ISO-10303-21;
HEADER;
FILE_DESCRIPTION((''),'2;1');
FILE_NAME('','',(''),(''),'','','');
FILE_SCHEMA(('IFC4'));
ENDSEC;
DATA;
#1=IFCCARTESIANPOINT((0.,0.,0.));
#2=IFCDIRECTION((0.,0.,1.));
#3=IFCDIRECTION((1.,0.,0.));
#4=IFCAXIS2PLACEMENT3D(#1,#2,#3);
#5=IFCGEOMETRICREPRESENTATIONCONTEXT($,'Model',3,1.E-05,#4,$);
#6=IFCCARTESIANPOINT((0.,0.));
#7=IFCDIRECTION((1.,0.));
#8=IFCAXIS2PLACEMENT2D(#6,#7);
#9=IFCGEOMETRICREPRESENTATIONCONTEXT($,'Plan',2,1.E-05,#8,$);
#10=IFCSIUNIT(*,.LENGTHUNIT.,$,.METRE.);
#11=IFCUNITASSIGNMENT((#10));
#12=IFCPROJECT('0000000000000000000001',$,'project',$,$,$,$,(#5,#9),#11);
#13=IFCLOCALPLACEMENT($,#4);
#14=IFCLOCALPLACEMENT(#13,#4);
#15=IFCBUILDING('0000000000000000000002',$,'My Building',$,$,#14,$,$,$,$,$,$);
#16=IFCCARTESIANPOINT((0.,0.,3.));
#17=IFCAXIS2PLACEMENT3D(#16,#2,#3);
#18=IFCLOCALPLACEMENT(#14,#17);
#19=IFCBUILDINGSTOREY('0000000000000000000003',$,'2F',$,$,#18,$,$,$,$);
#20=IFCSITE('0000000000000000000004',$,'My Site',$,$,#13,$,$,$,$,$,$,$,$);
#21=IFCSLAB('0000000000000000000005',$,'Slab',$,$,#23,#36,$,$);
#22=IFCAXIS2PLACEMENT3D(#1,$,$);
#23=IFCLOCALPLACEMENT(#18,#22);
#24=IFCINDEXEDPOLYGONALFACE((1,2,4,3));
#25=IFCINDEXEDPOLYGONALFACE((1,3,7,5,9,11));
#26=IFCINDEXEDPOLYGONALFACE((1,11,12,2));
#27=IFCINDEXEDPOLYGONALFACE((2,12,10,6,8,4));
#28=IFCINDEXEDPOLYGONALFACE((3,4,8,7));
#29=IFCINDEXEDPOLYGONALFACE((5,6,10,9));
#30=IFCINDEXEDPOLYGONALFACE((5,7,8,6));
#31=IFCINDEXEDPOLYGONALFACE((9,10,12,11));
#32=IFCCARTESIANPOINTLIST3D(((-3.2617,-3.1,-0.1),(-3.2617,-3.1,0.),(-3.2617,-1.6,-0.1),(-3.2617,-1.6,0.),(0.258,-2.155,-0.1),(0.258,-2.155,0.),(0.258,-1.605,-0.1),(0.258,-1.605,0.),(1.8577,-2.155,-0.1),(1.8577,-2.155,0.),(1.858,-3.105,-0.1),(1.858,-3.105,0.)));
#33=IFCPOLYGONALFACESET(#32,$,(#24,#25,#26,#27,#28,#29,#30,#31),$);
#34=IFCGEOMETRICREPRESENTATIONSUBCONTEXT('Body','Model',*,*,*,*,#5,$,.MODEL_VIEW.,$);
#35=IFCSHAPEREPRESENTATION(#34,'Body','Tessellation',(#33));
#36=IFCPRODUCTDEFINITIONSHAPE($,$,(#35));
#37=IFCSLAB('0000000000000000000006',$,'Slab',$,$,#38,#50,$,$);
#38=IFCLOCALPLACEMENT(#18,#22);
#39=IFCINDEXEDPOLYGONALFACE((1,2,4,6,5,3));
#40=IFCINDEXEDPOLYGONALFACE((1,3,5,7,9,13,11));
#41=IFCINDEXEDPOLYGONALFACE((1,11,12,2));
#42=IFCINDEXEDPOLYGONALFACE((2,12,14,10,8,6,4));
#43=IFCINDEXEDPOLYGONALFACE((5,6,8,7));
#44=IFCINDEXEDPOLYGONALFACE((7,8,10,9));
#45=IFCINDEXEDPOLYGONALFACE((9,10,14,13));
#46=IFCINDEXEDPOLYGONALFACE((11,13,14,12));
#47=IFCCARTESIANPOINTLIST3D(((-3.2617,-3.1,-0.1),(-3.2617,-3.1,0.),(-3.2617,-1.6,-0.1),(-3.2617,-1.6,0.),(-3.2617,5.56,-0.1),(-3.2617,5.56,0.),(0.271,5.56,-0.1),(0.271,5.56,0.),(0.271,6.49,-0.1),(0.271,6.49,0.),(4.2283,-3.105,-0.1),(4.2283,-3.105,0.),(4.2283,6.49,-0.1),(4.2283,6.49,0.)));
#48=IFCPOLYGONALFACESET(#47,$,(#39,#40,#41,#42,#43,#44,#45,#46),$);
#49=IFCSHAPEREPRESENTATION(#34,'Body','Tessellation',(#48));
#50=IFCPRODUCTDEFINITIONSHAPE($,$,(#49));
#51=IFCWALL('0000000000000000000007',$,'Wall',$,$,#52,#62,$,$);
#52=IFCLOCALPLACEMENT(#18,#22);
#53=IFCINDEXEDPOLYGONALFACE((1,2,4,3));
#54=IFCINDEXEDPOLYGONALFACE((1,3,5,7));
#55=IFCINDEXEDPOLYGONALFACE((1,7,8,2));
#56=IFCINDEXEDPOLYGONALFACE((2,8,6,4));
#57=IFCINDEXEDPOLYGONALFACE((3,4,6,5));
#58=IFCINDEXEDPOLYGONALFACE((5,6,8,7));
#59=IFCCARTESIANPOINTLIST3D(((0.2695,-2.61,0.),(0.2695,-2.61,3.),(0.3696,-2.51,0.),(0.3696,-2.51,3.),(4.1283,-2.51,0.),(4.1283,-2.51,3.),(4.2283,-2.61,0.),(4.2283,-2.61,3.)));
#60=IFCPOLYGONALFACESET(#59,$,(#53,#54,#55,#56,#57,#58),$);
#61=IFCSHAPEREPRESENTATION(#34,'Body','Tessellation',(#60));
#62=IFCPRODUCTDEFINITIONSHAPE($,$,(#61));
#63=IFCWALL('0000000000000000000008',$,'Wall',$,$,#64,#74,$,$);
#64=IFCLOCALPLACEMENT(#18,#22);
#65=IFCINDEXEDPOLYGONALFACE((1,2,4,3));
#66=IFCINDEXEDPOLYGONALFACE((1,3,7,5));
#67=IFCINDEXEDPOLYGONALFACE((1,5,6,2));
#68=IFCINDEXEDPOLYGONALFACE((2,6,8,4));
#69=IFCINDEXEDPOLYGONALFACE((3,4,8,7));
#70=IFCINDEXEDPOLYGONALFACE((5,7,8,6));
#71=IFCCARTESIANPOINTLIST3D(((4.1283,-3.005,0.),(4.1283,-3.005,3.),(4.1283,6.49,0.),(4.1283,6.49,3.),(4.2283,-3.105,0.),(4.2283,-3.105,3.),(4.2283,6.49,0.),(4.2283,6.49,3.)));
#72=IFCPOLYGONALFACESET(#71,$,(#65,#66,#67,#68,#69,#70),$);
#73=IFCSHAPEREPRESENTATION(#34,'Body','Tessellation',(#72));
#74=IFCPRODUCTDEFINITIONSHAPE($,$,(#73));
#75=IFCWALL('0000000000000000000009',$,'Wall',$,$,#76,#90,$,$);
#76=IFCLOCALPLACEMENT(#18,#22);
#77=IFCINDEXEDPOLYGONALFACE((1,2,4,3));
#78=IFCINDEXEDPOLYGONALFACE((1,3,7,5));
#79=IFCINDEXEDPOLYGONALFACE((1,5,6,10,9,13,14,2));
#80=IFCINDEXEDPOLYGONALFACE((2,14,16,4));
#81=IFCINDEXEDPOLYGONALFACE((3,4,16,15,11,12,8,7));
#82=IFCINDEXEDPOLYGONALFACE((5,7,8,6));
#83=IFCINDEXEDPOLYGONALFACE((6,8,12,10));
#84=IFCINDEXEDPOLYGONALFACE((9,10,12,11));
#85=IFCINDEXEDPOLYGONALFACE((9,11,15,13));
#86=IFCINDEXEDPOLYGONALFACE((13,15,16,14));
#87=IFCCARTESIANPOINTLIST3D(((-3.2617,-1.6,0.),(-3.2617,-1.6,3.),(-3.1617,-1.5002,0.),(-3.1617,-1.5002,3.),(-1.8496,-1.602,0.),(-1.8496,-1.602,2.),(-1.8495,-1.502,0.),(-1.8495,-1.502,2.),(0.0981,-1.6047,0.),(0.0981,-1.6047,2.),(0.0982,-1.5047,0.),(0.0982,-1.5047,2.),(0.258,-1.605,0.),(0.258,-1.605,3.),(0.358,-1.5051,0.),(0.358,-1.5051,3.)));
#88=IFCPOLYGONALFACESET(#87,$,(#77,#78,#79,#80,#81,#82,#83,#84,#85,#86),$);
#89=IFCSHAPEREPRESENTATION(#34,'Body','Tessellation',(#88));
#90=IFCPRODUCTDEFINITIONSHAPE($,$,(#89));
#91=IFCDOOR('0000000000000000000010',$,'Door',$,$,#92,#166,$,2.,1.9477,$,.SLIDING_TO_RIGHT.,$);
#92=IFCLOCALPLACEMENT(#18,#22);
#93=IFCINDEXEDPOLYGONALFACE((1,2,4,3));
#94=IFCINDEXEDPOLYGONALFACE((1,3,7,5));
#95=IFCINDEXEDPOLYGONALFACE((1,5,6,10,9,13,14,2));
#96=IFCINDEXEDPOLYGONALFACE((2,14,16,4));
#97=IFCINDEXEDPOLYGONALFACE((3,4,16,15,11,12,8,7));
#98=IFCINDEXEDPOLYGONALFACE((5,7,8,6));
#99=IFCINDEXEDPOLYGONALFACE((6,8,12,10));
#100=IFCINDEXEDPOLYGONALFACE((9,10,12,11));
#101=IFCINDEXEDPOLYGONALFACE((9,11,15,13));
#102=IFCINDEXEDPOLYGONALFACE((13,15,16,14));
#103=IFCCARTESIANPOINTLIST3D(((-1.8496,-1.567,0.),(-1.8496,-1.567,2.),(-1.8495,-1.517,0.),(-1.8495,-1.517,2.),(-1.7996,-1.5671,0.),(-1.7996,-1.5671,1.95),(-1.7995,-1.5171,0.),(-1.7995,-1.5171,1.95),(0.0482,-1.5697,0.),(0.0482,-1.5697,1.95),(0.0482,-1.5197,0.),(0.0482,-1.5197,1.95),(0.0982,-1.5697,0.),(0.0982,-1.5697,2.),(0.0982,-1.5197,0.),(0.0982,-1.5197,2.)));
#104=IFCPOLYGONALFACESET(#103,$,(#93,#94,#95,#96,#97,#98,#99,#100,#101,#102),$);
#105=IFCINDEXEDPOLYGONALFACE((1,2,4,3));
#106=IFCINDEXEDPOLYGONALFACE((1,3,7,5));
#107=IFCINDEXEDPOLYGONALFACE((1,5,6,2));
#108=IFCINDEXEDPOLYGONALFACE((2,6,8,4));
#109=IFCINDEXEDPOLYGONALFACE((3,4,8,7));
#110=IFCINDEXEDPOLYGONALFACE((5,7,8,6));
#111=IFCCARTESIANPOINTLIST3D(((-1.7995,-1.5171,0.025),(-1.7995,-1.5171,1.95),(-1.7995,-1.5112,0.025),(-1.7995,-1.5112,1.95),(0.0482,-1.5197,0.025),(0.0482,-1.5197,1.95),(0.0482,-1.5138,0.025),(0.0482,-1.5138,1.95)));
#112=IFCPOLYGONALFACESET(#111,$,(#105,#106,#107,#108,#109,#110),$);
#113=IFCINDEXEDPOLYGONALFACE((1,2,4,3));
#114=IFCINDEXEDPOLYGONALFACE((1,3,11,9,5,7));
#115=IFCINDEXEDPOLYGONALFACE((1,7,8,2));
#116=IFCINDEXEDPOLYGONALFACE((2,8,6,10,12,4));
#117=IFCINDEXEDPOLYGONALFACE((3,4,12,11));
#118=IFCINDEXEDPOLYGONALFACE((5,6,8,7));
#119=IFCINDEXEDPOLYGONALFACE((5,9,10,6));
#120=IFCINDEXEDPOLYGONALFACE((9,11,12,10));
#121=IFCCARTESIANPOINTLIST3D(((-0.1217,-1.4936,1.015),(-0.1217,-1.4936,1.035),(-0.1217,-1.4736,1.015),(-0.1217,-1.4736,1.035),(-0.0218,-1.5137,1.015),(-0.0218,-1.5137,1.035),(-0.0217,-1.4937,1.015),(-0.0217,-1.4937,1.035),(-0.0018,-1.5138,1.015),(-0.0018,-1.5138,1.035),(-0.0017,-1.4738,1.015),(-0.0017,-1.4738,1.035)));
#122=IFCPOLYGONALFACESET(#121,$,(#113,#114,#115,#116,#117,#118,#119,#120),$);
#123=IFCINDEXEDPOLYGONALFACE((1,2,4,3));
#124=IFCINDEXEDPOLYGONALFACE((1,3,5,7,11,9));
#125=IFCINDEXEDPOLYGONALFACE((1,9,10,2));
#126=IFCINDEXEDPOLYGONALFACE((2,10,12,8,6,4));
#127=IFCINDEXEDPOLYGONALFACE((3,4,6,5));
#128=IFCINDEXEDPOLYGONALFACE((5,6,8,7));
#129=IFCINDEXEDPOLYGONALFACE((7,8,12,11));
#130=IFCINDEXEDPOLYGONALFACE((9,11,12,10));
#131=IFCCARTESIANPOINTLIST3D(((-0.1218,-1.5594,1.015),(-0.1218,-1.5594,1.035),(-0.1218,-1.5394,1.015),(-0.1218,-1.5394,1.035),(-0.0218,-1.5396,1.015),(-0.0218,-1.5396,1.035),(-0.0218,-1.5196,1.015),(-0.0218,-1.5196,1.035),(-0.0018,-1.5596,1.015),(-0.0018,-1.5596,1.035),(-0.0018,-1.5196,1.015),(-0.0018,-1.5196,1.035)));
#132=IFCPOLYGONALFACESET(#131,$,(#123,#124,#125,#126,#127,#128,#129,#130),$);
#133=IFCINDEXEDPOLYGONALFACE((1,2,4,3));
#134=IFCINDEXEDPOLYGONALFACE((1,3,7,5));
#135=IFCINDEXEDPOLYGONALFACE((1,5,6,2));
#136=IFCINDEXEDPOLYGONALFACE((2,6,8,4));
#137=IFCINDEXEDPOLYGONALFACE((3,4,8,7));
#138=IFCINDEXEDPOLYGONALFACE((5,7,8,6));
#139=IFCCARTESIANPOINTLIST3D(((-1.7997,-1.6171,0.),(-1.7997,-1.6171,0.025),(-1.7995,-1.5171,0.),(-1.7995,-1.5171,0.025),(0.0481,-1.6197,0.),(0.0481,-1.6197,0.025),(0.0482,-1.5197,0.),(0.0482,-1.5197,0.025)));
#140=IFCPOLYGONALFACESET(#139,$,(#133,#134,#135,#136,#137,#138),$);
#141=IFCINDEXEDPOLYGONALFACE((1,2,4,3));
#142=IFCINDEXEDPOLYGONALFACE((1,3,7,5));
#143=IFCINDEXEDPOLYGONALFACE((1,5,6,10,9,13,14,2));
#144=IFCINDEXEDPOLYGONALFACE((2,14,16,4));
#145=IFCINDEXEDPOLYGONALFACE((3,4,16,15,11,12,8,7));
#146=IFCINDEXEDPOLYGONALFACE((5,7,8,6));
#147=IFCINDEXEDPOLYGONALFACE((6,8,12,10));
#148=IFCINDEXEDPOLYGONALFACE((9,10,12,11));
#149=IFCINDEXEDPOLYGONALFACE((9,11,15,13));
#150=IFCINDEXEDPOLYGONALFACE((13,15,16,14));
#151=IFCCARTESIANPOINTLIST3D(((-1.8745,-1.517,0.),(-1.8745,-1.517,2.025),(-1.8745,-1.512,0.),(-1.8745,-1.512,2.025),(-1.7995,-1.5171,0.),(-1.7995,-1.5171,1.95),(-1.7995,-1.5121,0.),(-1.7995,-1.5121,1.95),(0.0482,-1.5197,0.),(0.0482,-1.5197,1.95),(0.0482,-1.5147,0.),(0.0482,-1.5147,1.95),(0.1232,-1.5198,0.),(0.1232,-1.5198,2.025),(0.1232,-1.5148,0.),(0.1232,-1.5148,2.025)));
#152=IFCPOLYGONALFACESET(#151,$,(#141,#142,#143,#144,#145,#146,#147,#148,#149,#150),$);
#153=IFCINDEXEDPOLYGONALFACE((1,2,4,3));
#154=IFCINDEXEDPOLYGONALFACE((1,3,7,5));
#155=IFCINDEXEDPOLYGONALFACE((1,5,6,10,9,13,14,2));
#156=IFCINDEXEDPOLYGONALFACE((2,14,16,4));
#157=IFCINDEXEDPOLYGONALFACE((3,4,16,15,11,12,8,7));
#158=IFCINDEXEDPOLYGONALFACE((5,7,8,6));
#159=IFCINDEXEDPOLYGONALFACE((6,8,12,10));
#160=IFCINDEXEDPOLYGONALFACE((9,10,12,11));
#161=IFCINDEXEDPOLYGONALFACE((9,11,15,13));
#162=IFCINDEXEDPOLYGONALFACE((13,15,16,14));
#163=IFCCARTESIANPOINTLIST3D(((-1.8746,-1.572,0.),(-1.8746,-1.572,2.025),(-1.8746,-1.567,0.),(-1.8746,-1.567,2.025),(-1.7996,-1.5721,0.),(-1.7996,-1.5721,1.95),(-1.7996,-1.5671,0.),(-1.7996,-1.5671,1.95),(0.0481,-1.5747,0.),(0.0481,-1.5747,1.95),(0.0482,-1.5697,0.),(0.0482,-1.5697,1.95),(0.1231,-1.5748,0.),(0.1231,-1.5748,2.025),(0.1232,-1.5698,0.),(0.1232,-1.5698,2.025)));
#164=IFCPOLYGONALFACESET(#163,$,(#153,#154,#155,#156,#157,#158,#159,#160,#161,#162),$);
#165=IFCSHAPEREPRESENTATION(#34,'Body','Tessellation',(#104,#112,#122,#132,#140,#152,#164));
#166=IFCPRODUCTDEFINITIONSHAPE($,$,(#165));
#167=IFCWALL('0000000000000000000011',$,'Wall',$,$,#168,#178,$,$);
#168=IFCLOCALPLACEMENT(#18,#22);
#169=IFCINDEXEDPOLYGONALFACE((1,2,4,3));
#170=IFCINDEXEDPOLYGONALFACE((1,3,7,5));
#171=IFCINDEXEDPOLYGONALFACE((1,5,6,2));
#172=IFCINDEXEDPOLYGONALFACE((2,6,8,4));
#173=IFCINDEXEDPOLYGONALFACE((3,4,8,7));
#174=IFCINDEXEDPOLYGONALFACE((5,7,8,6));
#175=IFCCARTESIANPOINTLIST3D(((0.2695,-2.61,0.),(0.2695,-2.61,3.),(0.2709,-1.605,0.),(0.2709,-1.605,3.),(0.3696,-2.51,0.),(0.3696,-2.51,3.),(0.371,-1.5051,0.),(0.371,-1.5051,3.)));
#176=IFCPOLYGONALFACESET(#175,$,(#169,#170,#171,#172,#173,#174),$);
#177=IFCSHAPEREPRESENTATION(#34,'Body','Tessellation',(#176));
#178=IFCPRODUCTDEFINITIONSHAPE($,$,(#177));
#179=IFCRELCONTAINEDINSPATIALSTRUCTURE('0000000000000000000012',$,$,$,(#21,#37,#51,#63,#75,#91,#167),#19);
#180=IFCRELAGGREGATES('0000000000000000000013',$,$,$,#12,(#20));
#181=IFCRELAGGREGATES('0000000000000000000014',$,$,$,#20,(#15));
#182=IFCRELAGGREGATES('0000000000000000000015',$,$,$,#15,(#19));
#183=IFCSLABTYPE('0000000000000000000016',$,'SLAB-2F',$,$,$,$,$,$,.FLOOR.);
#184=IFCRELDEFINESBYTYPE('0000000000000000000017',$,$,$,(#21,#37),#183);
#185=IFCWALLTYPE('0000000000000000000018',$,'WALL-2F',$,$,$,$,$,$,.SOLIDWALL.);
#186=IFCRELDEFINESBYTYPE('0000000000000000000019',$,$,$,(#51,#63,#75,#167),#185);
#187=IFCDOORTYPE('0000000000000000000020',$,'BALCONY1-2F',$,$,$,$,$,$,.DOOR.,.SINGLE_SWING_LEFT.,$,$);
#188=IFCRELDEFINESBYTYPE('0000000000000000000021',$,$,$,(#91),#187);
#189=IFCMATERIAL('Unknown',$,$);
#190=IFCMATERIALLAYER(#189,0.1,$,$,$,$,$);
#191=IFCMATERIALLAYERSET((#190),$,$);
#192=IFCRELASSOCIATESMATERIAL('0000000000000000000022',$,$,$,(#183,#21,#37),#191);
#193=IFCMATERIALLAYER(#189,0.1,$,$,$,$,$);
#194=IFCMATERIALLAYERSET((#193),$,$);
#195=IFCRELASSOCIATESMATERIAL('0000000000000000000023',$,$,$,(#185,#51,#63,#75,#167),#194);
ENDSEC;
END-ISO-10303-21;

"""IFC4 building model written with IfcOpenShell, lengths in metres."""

from ifc_helpers import new_model, entity, si_unit, frame, origin_with_axes, origin_2d_with_axis, place, context, subcontext, project, spatial, line, indexed_curve, outline, extrude, shape, source, transform, mapped, material, layer, layer_set, layer_usage, type_object, type_shapes, element, fill, save


model = new_model("IFC4")

# Units and contexts
model_context = context("Model", 3, precision=1e-05, world=origin_with_axes())
plan_context = context("Plan", 2, precision=1e-05, world=origin_2d_with_axis())
body_context_1 = subcontext(model_context, "Body", "Model", "MODEL_VIEW")
body_context_2 = subcontext(plan_context, "Body", "Plan", "PLAN_VIEW")
ifc_project = project(units=[si_unit("LENGTHUNIT", "METRE")], contexts=[model_context, plan_context])

# Site, building, storey
site_placement = place(None, origin_with_axes())
site = spatial("IfcSite", under=ifc_project, at=site_placement, Name="My Site")
building_placement = place(site_placement, origin_with_axes())
building = spatial("IfcBuilding", under=site, at=building_placement, Name="My Building")
storey_placement = place(building_placement, frame((0.0, 0.0, 3.0), z_axis=(0.0, 0.0, 1.0), x_axis=(1.0, 0.0, 0.0)))
storey = spatial("IfcBuildingStorey", under=building, at=storey_placement, Name="2F")

# Slabs
ifc_material = material(Name="Unknown")
ifc_layer_1 = layer(ifc_material, 0.1)
ifc_layer_set_1 = layer_set([ifc_layer_1])
ifc_layer_usage_1 = layer_usage(ifc_layer_set_1, "AXIS3", "POSITIVE", -0.1)
slab_type = type_object("IfcSlabType", Name="SLAB-2F", PredefinedType="FLOOR", material=ifc_layer_set_1)
slab_1_placement = place(storey_placement, frame((-3.2617, -1.6, 0.0), z_axis=(0.0, 0.0, 1.0), x_axis=(1.0, 0.0, 0.0)))
element("IfcSlab", 1, at=slab_1_placement, inside=storey, type_object=slab_type, material=ifc_layer_usage_1, Name="Slab", context=body_context_1, shape_type="SweptSolid", body=[
    extrude(outline(indexed_curve([(0.0, 0.0), (0.0, -1.5), (5.1197, -1.5049), (5.1193, -0.5549), (3.5197, -0.5549), (3.5197, -0.0049), (0.0, 0.0)])), frame((0.0, 0.0, -0.1), z_axis=(0.0, 0.0, 1.0), x_axis=(1.0, 0.0, 0.0)), (0.0, 0.0, 1.0), 0.1),
])
ifc_layer_usage_2 = layer_usage(ifc_layer_set_1, "AXIS3", "POSITIVE", -0.1)
slab_2_placement = place(storey_placement, frame((-3.2617, -1.6, 0.0), z_axis=(0.0, 0.0, 1.0), x_axis=(1.0, 0.0, 0.0)))
element("IfcSlab", 2, at=slab_2_placement, inside=storey, type_object=slab_type, material=ifc_layer_usage_2, Name="Slab", context=body_context_1, shape_type="SweptSolid", body=[
    extrude(outline(indexed_curve([(0.0, 0.0), (0.0, -1.5), (7.49, -1.5049), (7.49, 8.09), (3.5327, 8.09), (3.5327, 7.16), (0.0, 7.16), (0.0, 0.0)])), frame((0.0, 0.0, -0.1), z_axis=(0.0, 0.0, 1.0), x_axis=(1.0, 0.0, 0.0)), (0.0, 0.0, 1.0), 0.1),
])

# Walls
ifc_layer_2 = layer(ifc_material, 0.1)
ifc_layer_set_2 = layer_set([ifc_layer_2])
ifc_layer_usage_3 = layer_usage(ifc_layer_set_2, "AXIS2", "POSITIVE", 0.0)
wall_type = type_object("IfcWallType", Name="WALL-2F", PredefinedType="SOLIDWALL", material=ifc_layer_set_2)
wall_1_placement = place(storey_placement, frame((0.2695, -2.61, 0.0), z_axis=(0.0, 0.0, 1.0), x_axis=(1.0, 0.0, 0.0)))
element("IfcWall", 3, at=wall_1_placement, inside=storey, type_object=wall_type, material=ifc_layer_usage_3, Name="Wall", context=body_context_1, shape_type="SweptSolid", body=[
    extrude(outline(indexed_curve([(0.0, 0.0), (0.1001, 0.1), (3.8589, 0.1), (3.9589, 0.0)], segments=[line(1, 2, 3, 4, 1)])), origin_with_axes(), (0.0, 0.0, 1.0), 3.0),
])
ifc_layer_usage_4 = layer_usage(ifc_layer_set_2, "AXIS2", "POSITIVE", 0.0)
wall_2_placement = place(storey_placement, frame((4.2283, -3.105, 0.0), z_axis=(0.0, 0.0, 1.0), x_axis=(0.0, 1.0, 0.0)))
element("IfcWall", 4, at=wall_2_placement, inside=storey, type_object=wall_type, material=ifc_layer_usage_4, Name="Wall", context=body_context_1, shape_type="SweptSolid", body=[
    extrude(outline(indexed_curve([(0.0, 0.0), (0.1, 0.1), (9.5949, 0.1), (9.5949, 0.0)], segments=[line(1, 2, 3, 4, 1)])), origin_with_axes(), (0.0, 0.0, 1.0), 3.0),
])

# Wall, opening, door
ifc_layer_usage_5 = layer_usage(ifc_layer_set_2, "AXIS2", "POSITIVE", 0.0)
wall_3_placement = place(storey_placement, frame((-3.2617, -1.6, 0.0), z_axis=(0.0, 0.0, 1.0), x_axis=(0.999999, -0.001402, 0.0)))
wall_3 = element("IfcWall", 5, at=wall_3_placement, inside=storey, type_object=wall_type, material=ifc_layer_usage_5, Name="Wall", context=body_context_1, shape_type="SweptSolid", body=[
    extrude(outline(indexed_curve([(0.0, 0.0), (0.0999, 0.1), (3.6195, 0.1), (3.5197, 0.0)], segments=[line(1, 2, 3, 4, 1)])), origin_with_axes(), (0.0, 0.0, 1.0), 3.0),
])
shared_shape_1 = source(origin_with_axes(), body_context_1, "Body", "SweptSolid", [
    extrude(outline(indexed_curve([(0.0, 0.0), (1.9477, 0.0), (1.9477, 2.0), (0.0, 2.0)], segments=[line(1, 2, 3, 4, 1)])), frame((0.0, -0.6, 0.0), z_axis=(0.0, -1.0, 0.0), x_axis=(1.0, 0.0, 0.0)), (0.0, 0.0, -1.0), 1.2),
])
opening_1_placement = place(wall_3_placement, frame((3.3598, 0.085, 0.0), z_axis=(0.0, 0.0, 1.0), x_axis=(-1.0, 0.0, 0.0)))
opening_1 = element("IfcOpeningElement", 6, at=opening_1_placement, cuts=wall_3, PredefinedType="OPENING", context=body_context_1, shape_type="MappedRepresentation", body=[
    mapped(shared_shape_1, transform((0.0, 0.0, 0.0), x_axis=(1.0, 0.0, 0.0), y_axis=(0.0, 1.0, 0.0), z_axis=(0.0, 0.0, 1.0), scale=1.0)),
])
door_type_1 = type_object("IfcDoorType", Name="BALCONY1-2F", OperationType="SINGLE_SWING_LEFT", PredefinedType="DOOR")
shared_shape_2 = source(origin_with_axes(), body_context_1, "Body", "SweptSolid", [
    extrude(outline(indexed_curve([(0.0, 0.0), (0.0, 2.0), (1.9477, 2.0), (1.9477, 0.0), (1.8977, 0.0), (1.8977, 1.95), (0.05, 1.95), (0.05, 0.0)], segments=[line(1, 2, 3, 4, 5, 6, 7, 8, 1)])), frame((0.0, 0.0, 0.0), z_axis=(0.0, -1.0, 0.0), x_axis=(1.0, 0.0, 0.0)), (0.0, 0.0, -1.0), 0.05),
    extrude(outline(indexed_curve([(0.0, 0.0), (1.8477, 0.0), (1.8477, 0.0058), (0.0, 0.0058)], segments=[line(1, 2, 3, 4, 1)])), frame((0.05, -0.0058, 0.025), z_axis=(0.0, 0.0, 1.0), x_axis=(1.0, 0.0, 0.0)), (0.0, 0.0, 1.0), 1.925),
    extrude(outline(indexed_curve([(0.0, 0.0), (0.0, -0.04), (0.12, -0.04), (0.12, -0.02), (0.02, -0.02), (0.02, 0.0)], segments=[line(1, 2, 3, 4, 5, 6, 1)])), frame((0.1, -0.0058, 1.015), z_axis=(0.0, 0.0, 1.0), x_axis=(1.0, 0.0, 0.0)), (0.0, 0.0, 1.0), 0.02),
    extrude(outline(indexed_curve([(0.0, 0.0), (0.0, 0.04), (0.12, 0.04), (0.12, 0.02), (0.02, 0.02), (0.02, 0.0)], segments=[line(1, 2, 3, 4, 5, 6, 1)])), frame((0.1, 0.0, 1.015), z_axis=(0.0, 0.0, 1.0), x_axis=(1.0, 0.0, 0.0)), (0.0, 0.0, 1.0), 0.02),
    extrude(outline(indexed_curve([(0.0, 0.0), (1.8477, 0.0), (1.8477, 0.1), (0.0, 0.1)], segments=[line(1, 2, 3, 4, 1)])), frame((0.05, 0.0, 0.0), z_axis=(0.0, 0.0, 1.0), x_axis=(1.0, 0.0, 0.0)), (0.0, 0.0, 1.0), 0.025),
    extrude(outline(indexed_curve([(0.0, 0.0), (0.0, 2.025), (1.9977, 2.025), (1.9977, 0.0), (1.9227, 0.0), (1.9227, 1.95), (0.075, 1.95), (0.075, 0.0)], segments=[line(1, 2, 3, 4, 5, 6, 7, 8, 1)])), frame((-0.025, -0.005, 0.0), z_axis=(0.0, -1.0, 0.0), x_axis=(1.0, 0.0, 0.0)), (0.0, 0.0, -1.0), 0.005),
    extrude(outline(indexed_curve([(0.0, 0.0), (0.0, 2.025), (1.9977, 2.025), (1.9977, 0.0), (1.9227, 0.0), (1.9227, 1.95), (0.075, 1.95), (0.075, 0.0)], segments=[line(1, 2, 3, 4, 5, 6, 7, 8, 1)])), frame((-0.025, 0.05, 0.0), z_axis=(0.0, -1.0, 0.0), x_axis=(1.0, 0.0, 0.0)), (0.0, 0.0, -1.0), 0.005),
])
shared_shape_3 = source(origin_with_axes(), body_context_2, "Body", "Curve2D", [
    entity("IfcIndexedPolyCurve", entity("IfcCartesianPointList2D", [[0.0, 0.0], [0.05, 0.0], [0.05, 0.05], [0.0, 0.05]]), [entity("IfcLineIndex", [1, 2, 3, 4, 1])]),
    entity("IfcIndexedPolyCurve", entity("IfcCartesianPointList2D", [[1.9477, 0.0], [1.8977, 0.0], [1.8977, 0.05], [1.9477, 0.05]]), [entity("IfcLineIndex", [1, 2, 3, 4, 1])]),
    entity("IfcIndexedPolyCurve", entity("IfcCartesianPointList2D", [[2.8216, -0.0058], [0.9739, -0.0058], [0.9739, 0.0], [2.8216, 0.0]]), [entity("IfcLineIndex", [1, 2, 3, 4, 1])]),
])
type_shapes(door_type_1, [shared_shape_2, shared_shape_3])
door_1_placement = place(opening_1_placement, frame((0.0, 0.0, 0.0), z_axis=(0.0, 0.0, 1.0), x_axis=(1.0, 0.0, 0.0)))
door_1 = element("IfcDoor", 7, at=door_1_placement, inside=storey, type_object=door_type_1, Name="Door", OperationType="SLIDING_TO_RIGHT", OverallHeight=2.0, OverallWidth=1.9477, shapes=[
    shape(body_context_1, "Body", "MappedRepresentation", [mapped(shared_shape_2, transform((0.0, 0.0, 0.0), x_axis=(1.0, 0.0, 0.0), y_axis=(0.0, 1.0, 0.0), z_axis=(0.0, 0.0, 1.0), scale=1.0))]),
    shape(body_context_2, "Body", "MappedRepresentation", [mapped(shared_shape_3, transform((0.0, 0.0, 0.0), x_axis=(1.0, 0.0, 0.0), y_axis=(0.0, 1.0, 0.0), z_axis=(0.0, 0.0, 1.0), scale=1.0))]),
])
fill(opening_1, door_1)

# Wall
ifc_layer_usage_6 = layer_usage(ifc_layer_set_2, "AXIS2", "POSITIVE", 0.0)
wall_4_placement = place(storey_placement, frame((0.2709, -1.605, 0.0), z_axis=(0.0, 0.0, 1.0), x_axis=(-0.001402, -0.999999, 0.0)))
element("IfcWall", 8, at=wall_4_placement, inside=storey, type_object=wall_type, material=ifc_layer_usage_6, Name="Wall", context=body_context_1, shape_type="SweptSolid", body=[
    extrude(outline(indexed_curve([(0.0, 0.0), (-0.1, 0.1), (0.9049, 0.1), (1.005, 0.0)], segments=[line(1, 2, 3, 4, 1)])), origin_with_axes(), (0.0, 0.0, 1.0), 3.0),
])

save(model, "model.ifc")
